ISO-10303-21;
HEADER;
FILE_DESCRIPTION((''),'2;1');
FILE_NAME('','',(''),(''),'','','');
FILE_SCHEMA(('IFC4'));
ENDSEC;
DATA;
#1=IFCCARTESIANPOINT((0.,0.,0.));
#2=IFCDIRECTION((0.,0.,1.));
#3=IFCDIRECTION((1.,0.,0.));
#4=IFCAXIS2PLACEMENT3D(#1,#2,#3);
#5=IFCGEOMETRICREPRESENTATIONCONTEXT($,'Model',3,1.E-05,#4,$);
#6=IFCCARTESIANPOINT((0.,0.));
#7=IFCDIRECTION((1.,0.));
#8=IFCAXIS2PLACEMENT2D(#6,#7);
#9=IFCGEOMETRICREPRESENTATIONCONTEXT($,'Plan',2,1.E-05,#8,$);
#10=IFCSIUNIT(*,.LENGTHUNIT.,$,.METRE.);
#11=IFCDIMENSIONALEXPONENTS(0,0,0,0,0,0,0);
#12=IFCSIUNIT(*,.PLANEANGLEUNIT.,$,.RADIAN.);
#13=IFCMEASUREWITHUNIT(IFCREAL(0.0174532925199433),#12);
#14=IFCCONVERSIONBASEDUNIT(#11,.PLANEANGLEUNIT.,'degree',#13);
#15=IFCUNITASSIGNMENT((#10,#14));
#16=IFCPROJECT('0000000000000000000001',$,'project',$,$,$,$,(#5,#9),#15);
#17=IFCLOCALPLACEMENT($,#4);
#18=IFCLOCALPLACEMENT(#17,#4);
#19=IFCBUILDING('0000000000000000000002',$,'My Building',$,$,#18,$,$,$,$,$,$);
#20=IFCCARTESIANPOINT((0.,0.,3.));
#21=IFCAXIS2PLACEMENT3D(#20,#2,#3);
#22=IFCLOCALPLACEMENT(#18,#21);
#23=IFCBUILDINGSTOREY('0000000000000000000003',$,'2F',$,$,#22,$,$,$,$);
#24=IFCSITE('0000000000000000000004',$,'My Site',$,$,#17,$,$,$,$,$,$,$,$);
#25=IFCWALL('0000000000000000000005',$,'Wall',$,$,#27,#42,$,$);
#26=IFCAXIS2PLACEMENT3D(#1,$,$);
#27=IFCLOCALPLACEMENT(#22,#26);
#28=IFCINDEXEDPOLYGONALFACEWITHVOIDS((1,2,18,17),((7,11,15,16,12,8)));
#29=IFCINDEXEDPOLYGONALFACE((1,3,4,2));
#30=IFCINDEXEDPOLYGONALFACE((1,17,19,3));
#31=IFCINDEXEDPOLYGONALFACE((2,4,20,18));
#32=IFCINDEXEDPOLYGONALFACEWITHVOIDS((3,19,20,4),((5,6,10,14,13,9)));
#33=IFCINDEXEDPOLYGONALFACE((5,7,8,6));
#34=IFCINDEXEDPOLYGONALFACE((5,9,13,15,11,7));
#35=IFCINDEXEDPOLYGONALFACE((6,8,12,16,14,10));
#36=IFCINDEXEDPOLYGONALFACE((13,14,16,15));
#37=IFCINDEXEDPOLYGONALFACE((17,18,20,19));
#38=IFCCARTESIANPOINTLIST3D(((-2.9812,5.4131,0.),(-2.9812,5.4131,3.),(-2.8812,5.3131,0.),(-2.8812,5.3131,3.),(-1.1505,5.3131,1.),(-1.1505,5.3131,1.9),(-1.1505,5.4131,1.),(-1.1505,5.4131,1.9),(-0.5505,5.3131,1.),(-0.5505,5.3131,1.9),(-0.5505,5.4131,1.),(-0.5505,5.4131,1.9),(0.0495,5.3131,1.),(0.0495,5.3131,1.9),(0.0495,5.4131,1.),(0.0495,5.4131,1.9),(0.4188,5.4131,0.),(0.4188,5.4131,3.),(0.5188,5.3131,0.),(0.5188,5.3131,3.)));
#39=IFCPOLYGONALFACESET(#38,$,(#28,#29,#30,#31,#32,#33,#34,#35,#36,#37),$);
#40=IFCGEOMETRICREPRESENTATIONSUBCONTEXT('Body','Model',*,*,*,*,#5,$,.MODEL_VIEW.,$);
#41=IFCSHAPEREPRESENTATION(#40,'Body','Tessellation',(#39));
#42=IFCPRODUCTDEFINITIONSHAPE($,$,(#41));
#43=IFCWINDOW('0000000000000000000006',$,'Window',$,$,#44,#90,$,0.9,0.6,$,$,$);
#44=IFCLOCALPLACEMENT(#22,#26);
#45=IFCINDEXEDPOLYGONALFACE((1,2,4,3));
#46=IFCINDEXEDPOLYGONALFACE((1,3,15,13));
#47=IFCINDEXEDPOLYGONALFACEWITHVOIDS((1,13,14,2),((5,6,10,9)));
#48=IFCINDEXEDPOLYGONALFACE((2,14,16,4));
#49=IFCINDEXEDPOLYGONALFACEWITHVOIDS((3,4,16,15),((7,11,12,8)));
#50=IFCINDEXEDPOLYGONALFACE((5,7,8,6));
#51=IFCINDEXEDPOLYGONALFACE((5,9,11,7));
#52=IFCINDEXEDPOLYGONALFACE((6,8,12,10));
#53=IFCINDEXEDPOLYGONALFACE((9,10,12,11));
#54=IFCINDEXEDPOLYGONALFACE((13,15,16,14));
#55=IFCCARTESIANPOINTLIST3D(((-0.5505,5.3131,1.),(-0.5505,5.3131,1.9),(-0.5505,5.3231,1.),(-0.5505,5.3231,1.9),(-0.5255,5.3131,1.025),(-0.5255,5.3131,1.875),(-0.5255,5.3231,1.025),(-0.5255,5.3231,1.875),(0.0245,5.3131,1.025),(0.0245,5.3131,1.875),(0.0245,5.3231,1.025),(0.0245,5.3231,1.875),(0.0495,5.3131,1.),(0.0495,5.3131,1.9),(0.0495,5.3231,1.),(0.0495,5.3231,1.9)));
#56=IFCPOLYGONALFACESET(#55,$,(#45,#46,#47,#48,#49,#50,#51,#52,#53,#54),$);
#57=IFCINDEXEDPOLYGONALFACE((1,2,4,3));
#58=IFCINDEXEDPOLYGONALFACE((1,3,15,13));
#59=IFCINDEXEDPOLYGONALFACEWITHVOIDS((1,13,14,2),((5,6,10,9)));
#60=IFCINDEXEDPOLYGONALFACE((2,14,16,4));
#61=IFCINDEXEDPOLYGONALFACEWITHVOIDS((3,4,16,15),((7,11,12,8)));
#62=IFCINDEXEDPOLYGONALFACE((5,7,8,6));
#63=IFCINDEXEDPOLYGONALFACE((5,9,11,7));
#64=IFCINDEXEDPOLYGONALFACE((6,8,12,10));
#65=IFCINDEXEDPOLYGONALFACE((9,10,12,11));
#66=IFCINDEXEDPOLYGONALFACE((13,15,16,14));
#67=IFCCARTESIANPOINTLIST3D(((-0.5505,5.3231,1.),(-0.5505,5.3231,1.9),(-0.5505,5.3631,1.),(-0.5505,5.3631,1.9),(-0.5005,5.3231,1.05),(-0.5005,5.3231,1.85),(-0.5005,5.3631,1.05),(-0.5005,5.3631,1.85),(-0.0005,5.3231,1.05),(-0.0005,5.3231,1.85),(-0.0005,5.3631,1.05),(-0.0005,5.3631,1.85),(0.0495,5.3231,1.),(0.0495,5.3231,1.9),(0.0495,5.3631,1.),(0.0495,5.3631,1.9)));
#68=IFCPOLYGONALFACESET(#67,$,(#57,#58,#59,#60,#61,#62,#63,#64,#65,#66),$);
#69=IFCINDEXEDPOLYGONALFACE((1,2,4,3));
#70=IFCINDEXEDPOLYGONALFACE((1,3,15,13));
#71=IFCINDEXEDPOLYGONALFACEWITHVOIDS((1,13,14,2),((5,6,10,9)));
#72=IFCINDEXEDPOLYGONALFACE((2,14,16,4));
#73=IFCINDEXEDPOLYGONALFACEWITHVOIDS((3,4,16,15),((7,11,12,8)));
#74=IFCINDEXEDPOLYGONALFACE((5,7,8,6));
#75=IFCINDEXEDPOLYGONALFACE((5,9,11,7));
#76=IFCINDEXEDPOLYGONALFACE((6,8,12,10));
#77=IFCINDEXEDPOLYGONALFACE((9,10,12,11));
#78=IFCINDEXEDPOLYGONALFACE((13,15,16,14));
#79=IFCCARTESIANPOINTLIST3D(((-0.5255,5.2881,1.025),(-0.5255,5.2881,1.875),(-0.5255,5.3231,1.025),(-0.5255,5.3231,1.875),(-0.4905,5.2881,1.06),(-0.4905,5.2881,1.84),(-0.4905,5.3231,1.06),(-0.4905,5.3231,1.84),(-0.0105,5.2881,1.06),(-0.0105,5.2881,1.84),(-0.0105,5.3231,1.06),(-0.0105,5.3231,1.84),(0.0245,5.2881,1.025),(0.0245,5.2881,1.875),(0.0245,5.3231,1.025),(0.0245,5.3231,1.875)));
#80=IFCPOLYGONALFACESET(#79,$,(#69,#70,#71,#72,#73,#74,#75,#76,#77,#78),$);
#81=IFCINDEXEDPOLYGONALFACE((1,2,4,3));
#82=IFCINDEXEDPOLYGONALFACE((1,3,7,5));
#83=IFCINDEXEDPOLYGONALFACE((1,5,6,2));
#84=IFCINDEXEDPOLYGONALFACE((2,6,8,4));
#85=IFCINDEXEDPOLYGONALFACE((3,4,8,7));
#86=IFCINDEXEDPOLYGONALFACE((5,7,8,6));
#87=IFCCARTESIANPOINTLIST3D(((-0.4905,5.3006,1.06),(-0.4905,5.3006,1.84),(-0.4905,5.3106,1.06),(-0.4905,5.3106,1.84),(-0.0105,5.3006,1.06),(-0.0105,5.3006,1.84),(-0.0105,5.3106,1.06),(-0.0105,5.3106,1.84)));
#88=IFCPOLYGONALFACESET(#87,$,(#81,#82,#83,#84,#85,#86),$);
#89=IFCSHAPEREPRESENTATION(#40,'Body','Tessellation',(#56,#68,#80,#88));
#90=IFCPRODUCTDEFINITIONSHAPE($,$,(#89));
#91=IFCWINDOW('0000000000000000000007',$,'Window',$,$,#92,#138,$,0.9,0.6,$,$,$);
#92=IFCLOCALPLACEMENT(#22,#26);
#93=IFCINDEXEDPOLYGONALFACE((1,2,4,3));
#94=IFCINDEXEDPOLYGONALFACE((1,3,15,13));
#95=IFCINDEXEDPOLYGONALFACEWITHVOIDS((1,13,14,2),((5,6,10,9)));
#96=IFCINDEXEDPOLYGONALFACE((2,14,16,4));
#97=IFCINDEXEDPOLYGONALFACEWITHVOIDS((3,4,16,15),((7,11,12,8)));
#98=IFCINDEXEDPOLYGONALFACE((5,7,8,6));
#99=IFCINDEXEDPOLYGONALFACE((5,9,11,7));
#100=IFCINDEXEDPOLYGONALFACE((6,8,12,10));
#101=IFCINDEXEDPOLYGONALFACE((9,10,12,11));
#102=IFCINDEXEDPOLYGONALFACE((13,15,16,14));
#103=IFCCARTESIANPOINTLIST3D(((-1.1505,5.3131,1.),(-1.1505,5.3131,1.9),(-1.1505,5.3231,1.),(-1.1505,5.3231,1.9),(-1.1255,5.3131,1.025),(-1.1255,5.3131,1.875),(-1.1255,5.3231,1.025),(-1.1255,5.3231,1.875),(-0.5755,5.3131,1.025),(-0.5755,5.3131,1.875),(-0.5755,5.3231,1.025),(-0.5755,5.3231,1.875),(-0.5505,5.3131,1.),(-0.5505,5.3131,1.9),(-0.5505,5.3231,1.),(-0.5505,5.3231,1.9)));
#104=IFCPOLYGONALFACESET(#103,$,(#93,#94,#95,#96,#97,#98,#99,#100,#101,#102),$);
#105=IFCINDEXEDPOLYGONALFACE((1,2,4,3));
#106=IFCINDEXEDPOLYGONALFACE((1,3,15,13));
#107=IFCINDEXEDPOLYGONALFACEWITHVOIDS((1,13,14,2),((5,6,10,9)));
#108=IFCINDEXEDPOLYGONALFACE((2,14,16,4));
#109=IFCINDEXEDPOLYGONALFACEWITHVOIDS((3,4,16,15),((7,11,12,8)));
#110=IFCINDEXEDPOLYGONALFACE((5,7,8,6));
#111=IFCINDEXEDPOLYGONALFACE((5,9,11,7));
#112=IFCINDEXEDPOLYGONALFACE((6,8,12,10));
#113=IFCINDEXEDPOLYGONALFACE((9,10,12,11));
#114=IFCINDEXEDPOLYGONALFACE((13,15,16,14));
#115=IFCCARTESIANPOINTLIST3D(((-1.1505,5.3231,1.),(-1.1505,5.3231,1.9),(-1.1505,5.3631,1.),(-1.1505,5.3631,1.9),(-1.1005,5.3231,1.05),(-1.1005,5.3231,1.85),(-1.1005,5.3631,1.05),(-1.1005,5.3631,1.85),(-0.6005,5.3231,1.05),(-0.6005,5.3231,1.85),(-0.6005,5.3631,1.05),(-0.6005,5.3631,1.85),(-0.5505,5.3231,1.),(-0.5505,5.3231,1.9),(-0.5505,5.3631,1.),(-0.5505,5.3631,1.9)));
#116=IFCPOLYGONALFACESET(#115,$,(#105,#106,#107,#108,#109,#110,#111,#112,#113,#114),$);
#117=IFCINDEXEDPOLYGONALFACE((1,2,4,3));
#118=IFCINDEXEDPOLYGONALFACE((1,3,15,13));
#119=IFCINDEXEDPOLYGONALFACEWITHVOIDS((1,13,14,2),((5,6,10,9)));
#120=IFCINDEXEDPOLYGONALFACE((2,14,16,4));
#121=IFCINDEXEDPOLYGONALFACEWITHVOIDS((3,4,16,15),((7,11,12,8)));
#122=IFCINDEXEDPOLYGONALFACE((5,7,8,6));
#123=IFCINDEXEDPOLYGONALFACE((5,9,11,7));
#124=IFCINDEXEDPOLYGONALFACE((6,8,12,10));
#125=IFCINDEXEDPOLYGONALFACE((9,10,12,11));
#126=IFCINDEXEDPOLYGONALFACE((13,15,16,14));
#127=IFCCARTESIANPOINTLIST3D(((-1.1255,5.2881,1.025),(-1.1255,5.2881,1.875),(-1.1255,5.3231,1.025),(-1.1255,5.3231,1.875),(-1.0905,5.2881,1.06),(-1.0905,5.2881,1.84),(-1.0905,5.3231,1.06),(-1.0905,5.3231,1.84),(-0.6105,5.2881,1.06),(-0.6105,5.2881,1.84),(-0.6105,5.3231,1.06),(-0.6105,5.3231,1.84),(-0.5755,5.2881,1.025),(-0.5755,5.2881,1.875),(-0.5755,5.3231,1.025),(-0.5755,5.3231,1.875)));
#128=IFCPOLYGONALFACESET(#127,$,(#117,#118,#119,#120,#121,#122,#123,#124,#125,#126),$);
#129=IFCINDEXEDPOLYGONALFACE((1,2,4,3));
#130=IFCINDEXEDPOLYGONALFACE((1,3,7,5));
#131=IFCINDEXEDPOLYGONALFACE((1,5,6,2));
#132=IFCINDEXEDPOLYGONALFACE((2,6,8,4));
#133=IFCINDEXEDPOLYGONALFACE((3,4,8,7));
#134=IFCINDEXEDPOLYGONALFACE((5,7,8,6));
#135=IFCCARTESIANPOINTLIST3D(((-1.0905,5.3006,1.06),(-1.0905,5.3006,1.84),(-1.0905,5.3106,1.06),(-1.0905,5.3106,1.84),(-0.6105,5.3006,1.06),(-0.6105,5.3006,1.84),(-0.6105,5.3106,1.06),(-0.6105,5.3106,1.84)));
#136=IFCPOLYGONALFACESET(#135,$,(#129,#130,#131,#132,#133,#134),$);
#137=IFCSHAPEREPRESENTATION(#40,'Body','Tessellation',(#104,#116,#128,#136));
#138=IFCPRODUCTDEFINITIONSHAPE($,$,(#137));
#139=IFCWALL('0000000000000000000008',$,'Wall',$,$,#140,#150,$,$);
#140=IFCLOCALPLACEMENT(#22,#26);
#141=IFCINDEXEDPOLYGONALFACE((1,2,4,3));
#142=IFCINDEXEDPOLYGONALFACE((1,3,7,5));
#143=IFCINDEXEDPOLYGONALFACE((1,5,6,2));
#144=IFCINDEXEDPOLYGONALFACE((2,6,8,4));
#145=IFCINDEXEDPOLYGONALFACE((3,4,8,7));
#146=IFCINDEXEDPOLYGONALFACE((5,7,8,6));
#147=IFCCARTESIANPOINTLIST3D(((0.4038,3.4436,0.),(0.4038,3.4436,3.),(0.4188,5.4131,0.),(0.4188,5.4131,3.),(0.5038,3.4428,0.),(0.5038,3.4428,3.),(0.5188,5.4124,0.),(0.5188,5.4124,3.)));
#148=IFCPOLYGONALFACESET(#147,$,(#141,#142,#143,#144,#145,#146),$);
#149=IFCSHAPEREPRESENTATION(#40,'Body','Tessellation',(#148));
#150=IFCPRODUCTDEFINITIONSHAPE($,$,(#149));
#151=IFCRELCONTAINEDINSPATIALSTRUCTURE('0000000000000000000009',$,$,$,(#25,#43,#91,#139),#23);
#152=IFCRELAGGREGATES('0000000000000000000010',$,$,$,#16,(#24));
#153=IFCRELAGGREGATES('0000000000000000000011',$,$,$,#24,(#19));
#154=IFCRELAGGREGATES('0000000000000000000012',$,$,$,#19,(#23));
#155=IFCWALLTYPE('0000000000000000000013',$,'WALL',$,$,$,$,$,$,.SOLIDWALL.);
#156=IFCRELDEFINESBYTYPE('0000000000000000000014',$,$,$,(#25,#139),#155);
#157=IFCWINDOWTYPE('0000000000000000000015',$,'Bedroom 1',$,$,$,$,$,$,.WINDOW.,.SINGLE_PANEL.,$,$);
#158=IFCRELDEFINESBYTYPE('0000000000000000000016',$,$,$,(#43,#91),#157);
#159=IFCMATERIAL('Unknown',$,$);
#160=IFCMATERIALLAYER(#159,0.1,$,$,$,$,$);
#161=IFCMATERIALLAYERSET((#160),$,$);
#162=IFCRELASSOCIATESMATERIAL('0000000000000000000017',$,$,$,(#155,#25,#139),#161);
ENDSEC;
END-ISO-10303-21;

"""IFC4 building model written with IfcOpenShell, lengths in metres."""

from ifc_helpers import new_model, entity, si_unit, converted_unit, frame, origin_with_axes, origin_2d_with_axis, place, context, subcontext, project, spatial, line, indexed_curve, outline, extrude, shape, source, transform, mapped, material, layer, layer_set, layer_usage, type_object, type_shapes, element, fill, save


model = new_model("IFC4")

# Units and contexts
model_context = context("Model", 3, precision=1e-05, world=origin_with_axes())
plan_context = context("Plan", 2, precision=1e-05, world=origin_2d_with_axis())
body_context_1 = subcontext(model_context, "Body", "Model", "MODEL_VIEW")
body_context_2 = subcontext(plan_context, "Body", "Plan", "PLAN_VIEW")
ifc_project = project(units=[si_unit("LENGTHUNIT", "METRE"), converted_unit("PLANEANGLEUNIT", "degree", entity("IfcReal", 0.0174532925199433), si_unit("PLANEANGLEUNIT", "RADIAN"), dimensions=[0, 0, 0, 0, 0, 0, 0])], contexts=[model_context, plan_context])

# Site, building, storey
site_placement = place(None, origin_with_axes())
site = spatial("IfcSite", under=ifc_project, at=site_placement, Name="My Site")
building_placement = place(site_placement, origin_with_axes())
building = spatial("IfcBuilding", under=site, at=building_placement, Name="My Building")
storey_placement = place(building_placement, frame((0.0, 0.0, 3.0), z_axis=(0.0, 0.0, 1.0), x_axis=(1.0, 0.0, 0.0)))
storey = spatial("IfcBuildingStorey", under=building, at=storey_placement, Name="2F")

# Shared definitions
ifc_material = material(Name="Unknown")

# Shared definitions
ifc_layer_1 = layer(ifc_material, 0.1)
ifc_layer_set_1 = layer_set([ifc_layer_1])
wall_type = type_object("IfcWallType", Name="WALL", PredefinedType="SOLIDWALL", material=ifc_layer_set_1)

# Wall, openings, windows
ifc_layer_usage_1 = layer_usage(ifc_layer_set_1, "AXIS2", "POSITIVE", 0.0)
wall_1_placement = place(storey_placement, frame((0.4188, 5.4131, 0.0), z_axis=(0.0, 0.0, 1.0), x_axis=(-1.0, 0.0, 0.0)))
wall_1 = element("IfcWall", 1, at=wall_1_placement, inside=storey, type_object=wall_type, material=ifc_layer_usage_1, Name="Wall", context=body_context_1, shape_type="SweptSolid", body=[
    extrude(outline(indexed_curve([(0.0, 0.0), (-0.1, 0.1), (3.3, 0.1), (3.4, 0.0)], segments=[line(1, 2, 3, 4, 1)])), origin_with_axes(), (0.0, 0.0, 1.0), 3.0),
])
shared_shape_1 = source(origin_with_axes(), body_context_1, "Body", "SweptSolid", [
    extrude(outline(indexed_curve([(0.0, 0.0), (0.6, 0.0), (0.6, 0.9), (0.0, 0.9)], segments=[line(1, 2, 3, 4, 1)])), frame((0.0, -0.6, 0.0), z_axis=(0.0, -1.0, 0.0), x_axis=(1.0, 0.0, 0.0)), (0.0, 0.0, -1.0), 1.2),
])
opening_1_placement = place(wall_1_placement, frame((0.3694, 0.0, 1.0), z_axis=(0.0, 0.0, 1.0), x_axis=(1.0, 0.0, 0.0)))
opening_1 = element("IfcOpeningElement", 2, at=opening_1_placement, cuts=wall_1, PredefinedType="OPENING", context=body_context_1, shape_type="MappedRepresentation", body=[
    mapped(shared_shape_1, transform((0.0, 0.0, 0.0), x_axis=(1.0, 0.0, 0.0), y_axis=(0.0, 1.0, 0.0), z_axis=(0.0, 0.0, 1.0), scale=1.0)),
])
opening_2_placement = place(wall_1_placement, frame((0.9694, 0.0, 1.0), z_axis=(0.0, 0.0, 1.0), x_axis=(1.0, 0.0, 0.0)))
opening_2 = element("IfcOpeningElement", 3, at=opening_2_placement, cuts=wall_1, PredefinedType="OPENING", context=body_context_1, shape_type="MappedRepresentation", body=[
    mapped(shared_shape_1, transform((0.0, 0.0, 0.0), x_axis=(1.0, 0.0, 0.0), y_axis=(0.0, 1.0, 0.0), z_axis=(0.0, 0.0, 1.0), scale=1.0)),
])
window_type_1 = type_object("IfcWindowType", Name="Bedroom 1", PartitioningType="SINGLE_PANEL", PredefinedType="WINDOW")
shared_shape_2 = source(origin_with_axes(), body_context_1, "Body", "SweptSolid", [
    extrude(outline(indexed_curve([(0.0, 0.0), (0.6, 0.0), (0.6, 0.9), (0.0, 0.9)], segments=[line(1, 2, 3, 4, 1)]), holes=[indexed_curve([(0.025, 0.025), (0.575, 0.025), (0.575, 0.875), (0.025, 0.875)], segments=[line(1, 2, 3, 4, 1)])]), frame((0.0, 0.09, 0.0), z_axis=(0.0, -1.0, 0.0), x_axis=(1.0, 0.0, 0.0)), (0.0, 0.0, -1.0), 0.01),
    extrude(outline(indexed_curve([(0.0, 0.0), (0.6, 0.0), (0.6, 0.9), (0.0, 0.9)], segments=[line(1, 2, 3, 4, 1)]), holes=[indexed_curve([(0.05, 0.05), (0.55, 0.05), (0.55, 0.85), (0.05, 0.85)], segments=[line(1, 2, 3, 4, 1)])]), frame((0.0, 0.05, 0.0), z_axis=(0.0, -1.0, 0.0), x_axis=(1.0, 0.0, 0.0)), (0.0, 0.0, -1.0), 0.04),
    extrude(outline(indexed_curve([(0.0, 0.0), (0.55, 0.0), (0.55, 0.85), (0.0, 0.85)], segments=[line(1, 2, 3, 4, 1)]), holes=[indexed_curve([(0.035, 0.035), (0.515, 0.035), (0.515, 0.815), (0.035, 0.815)], segments=[line(1, 2, 3, 4, 1)])]), frame((0.025, 0.09, 0.025), z_axis=(0.0, -1.0, 0.0), x_axis=(1.0, 0.0, 0.0)), (0.0, 0.0, -1.0), 0.035),
    extrude(outline(indexed_curve([(0.035, 0.035), (0.515, 0.035), (0.515, 0.815), (0.035, 0.815)], segments=[line(1, 2, 3, 4, 1)])), frame((0.025, 0.1025, 0.025), z_axis=(0.0, -1.0, 0.0), x_axis=(1.0, 0.0, 0.0)), (0.0, 0.0, -1.0), 0.01),
])
shared_shape_3 = source(origin_with_axes(), body_context_2, "Body", "Curve2D", [
    entity("IfcIndexedPolyCurve", entity("IfcCartesianPointList2D", [[0.05, 0.05], [0.55, 0.05]])),
    entity("IfcIndexedPolyCurve", entity("IfcCartesianPointList2D", [[0.0, 0.1], [0.025, 0.1], [0.025, 0.09], [0.05, 0.09], [0.05, 0.05], [0.0, 0.05]]), [entity("IfcLineIndex", [1, 2, 3, 4, 5, 6, 1])]),
    entity("IfcIndexedPolyCurve", entity("IfcCartesianPointList2D", [[0.6, 0.1], [0.575, 0.1], [0.575, 0.09], [0.55, 0.09], [0.55, 0.05], [0.6, 0.05]]), [entity("IfcLineIndex", [1, 2, 3, 4, 5, 6, 1])]),
    entity("IfcIndexedPolyCurve", entity("IfcCartesianPointList2D", [[0.025, 0.09], [0.06, 0.09], [0.06, 0.125], [0.025, 0.125]]), [entity("IfcLineIndex", [1, 2, 3, 4, 1])]),
    entity("IfcIndexedPolyCurve", entity("IfcCartesianPointList2D", [[0.575, 0.09], [0.54, 0.09], [0.54, 0.125], [0.575, 0.125]]), [entity("IfcLineIndex", [1, 2, 3, 4, 1])]),
    entity("IfcIndexedPolyCurve", entity("IfcCartesianPointList2D", [[0.06, 0.09], [0.54, 0.09]])),
    entity("IfcIndexedPolyCurve", entity("IfcCartesianPointList2D", [[0.06, 0.125], [0.54, 0.125]])),
    entity("IfcIndexedPolyCurve", entity("IfcCartesianPointList2D", [[0.06, 0.1075], [0.54, 0.1075]])),
])
type_shapes(window_type_1, [shared_shape_2, shared_shape_3])
window_1_placement = place(opening_1_placement, frame((0.0, 0.0, 0.0), z_axis=(0.0, 0.0, 1.0), x_axis=(1.0, 0.0, 0.0)))
window_1 = element("IfcWindow", 4, at=window_1_placement, inside=storey, type_object=window_type_1, Name="Window", OverallHeight=0.9, OverallWidth=0.6, shapes=[
    shape(body_context_1, "Body", "MappedRepresentation", [mapped(shared_shape_2, transform((0.0, 0.0, 0.0), x_axis=(1.0, 0.0, 0.0), y_axis=(0.0, 1.0, 0.0), z_axis=(0.0, 0.0, 1.0), scale=1.0))]),
    shape(body_context_2, "Body", "MappedRepresentation", [mapped(shared_shape_3, transform((0.0, 0.0, 0.0), x_axis=(1.0, 0.0, 0.0), y_axis=(0.0, 1.0, 0.0), z_axis=(0.0, 0.0, 1.0), scale=1.0))]),
])
fill(opening_1, window_1)
window_2_placement = place(opening_2_placement, origin_with_axes())
window_2 = element("IfcWindow", 5, at=window_2_placement, inside=storey, type_object=window_type_1, Name="Window", OverallHeight=0.9, OverallWidth=0.6, shapes=[
    shape(body_context_1, "Body", "MappedRepresentation", [mapped(shared_shape_2, transform((0.0, 0.0, 0.0), x_axis=(1.0, 0.0, 0.0), y_axis=(0.0, 1.0, 0.0), z_axis=(0.0, 0.0, 1.0), scale=1.0))]),
    shape(body_context_2, "Body", "MappedRepresentation", [mapped(shared_shape_3, transform((0.0, 0.0, 0.0), x_axis=(1.0, 0.0, 0.0), y_axis=(0.0, 1.0, 0.0), z_axis=(0.0, 0.0, 1.0), scale=1.0))]),
])
fill(opening_2, window_2)

# Wall
ifc_layer_usage_2 = layer_usage(ifc_layer_set_1, "AXIS2", "POSITIVE", 0.0)
wall_2_placement = place(storey_placement, frame((0.4188, 5.4131, 0.0), z_axis=(0.0, 0.0, 1.0), x_axis=(-0.007642, -0.999971, 0.0)))
element("IfcWall", 6, at=wall_2_placement, inside=storey, type_object=wall_type, material=ifc_layer_usage_2, Name="Wall", context=body_context_1, shape_type="SweptSolid", body=[
    extrude(outline(indexed_curve([(0.0, 0.0), (0.0, 0.1), (1.9696, 0.1), (1.9696, 0.0)], segments=[line(1, 2, 3, 4, 1)])), origin_with_axes(), (0.0, 0.0, 1.0), 3.0),
])

save(model, "model.ifc")
